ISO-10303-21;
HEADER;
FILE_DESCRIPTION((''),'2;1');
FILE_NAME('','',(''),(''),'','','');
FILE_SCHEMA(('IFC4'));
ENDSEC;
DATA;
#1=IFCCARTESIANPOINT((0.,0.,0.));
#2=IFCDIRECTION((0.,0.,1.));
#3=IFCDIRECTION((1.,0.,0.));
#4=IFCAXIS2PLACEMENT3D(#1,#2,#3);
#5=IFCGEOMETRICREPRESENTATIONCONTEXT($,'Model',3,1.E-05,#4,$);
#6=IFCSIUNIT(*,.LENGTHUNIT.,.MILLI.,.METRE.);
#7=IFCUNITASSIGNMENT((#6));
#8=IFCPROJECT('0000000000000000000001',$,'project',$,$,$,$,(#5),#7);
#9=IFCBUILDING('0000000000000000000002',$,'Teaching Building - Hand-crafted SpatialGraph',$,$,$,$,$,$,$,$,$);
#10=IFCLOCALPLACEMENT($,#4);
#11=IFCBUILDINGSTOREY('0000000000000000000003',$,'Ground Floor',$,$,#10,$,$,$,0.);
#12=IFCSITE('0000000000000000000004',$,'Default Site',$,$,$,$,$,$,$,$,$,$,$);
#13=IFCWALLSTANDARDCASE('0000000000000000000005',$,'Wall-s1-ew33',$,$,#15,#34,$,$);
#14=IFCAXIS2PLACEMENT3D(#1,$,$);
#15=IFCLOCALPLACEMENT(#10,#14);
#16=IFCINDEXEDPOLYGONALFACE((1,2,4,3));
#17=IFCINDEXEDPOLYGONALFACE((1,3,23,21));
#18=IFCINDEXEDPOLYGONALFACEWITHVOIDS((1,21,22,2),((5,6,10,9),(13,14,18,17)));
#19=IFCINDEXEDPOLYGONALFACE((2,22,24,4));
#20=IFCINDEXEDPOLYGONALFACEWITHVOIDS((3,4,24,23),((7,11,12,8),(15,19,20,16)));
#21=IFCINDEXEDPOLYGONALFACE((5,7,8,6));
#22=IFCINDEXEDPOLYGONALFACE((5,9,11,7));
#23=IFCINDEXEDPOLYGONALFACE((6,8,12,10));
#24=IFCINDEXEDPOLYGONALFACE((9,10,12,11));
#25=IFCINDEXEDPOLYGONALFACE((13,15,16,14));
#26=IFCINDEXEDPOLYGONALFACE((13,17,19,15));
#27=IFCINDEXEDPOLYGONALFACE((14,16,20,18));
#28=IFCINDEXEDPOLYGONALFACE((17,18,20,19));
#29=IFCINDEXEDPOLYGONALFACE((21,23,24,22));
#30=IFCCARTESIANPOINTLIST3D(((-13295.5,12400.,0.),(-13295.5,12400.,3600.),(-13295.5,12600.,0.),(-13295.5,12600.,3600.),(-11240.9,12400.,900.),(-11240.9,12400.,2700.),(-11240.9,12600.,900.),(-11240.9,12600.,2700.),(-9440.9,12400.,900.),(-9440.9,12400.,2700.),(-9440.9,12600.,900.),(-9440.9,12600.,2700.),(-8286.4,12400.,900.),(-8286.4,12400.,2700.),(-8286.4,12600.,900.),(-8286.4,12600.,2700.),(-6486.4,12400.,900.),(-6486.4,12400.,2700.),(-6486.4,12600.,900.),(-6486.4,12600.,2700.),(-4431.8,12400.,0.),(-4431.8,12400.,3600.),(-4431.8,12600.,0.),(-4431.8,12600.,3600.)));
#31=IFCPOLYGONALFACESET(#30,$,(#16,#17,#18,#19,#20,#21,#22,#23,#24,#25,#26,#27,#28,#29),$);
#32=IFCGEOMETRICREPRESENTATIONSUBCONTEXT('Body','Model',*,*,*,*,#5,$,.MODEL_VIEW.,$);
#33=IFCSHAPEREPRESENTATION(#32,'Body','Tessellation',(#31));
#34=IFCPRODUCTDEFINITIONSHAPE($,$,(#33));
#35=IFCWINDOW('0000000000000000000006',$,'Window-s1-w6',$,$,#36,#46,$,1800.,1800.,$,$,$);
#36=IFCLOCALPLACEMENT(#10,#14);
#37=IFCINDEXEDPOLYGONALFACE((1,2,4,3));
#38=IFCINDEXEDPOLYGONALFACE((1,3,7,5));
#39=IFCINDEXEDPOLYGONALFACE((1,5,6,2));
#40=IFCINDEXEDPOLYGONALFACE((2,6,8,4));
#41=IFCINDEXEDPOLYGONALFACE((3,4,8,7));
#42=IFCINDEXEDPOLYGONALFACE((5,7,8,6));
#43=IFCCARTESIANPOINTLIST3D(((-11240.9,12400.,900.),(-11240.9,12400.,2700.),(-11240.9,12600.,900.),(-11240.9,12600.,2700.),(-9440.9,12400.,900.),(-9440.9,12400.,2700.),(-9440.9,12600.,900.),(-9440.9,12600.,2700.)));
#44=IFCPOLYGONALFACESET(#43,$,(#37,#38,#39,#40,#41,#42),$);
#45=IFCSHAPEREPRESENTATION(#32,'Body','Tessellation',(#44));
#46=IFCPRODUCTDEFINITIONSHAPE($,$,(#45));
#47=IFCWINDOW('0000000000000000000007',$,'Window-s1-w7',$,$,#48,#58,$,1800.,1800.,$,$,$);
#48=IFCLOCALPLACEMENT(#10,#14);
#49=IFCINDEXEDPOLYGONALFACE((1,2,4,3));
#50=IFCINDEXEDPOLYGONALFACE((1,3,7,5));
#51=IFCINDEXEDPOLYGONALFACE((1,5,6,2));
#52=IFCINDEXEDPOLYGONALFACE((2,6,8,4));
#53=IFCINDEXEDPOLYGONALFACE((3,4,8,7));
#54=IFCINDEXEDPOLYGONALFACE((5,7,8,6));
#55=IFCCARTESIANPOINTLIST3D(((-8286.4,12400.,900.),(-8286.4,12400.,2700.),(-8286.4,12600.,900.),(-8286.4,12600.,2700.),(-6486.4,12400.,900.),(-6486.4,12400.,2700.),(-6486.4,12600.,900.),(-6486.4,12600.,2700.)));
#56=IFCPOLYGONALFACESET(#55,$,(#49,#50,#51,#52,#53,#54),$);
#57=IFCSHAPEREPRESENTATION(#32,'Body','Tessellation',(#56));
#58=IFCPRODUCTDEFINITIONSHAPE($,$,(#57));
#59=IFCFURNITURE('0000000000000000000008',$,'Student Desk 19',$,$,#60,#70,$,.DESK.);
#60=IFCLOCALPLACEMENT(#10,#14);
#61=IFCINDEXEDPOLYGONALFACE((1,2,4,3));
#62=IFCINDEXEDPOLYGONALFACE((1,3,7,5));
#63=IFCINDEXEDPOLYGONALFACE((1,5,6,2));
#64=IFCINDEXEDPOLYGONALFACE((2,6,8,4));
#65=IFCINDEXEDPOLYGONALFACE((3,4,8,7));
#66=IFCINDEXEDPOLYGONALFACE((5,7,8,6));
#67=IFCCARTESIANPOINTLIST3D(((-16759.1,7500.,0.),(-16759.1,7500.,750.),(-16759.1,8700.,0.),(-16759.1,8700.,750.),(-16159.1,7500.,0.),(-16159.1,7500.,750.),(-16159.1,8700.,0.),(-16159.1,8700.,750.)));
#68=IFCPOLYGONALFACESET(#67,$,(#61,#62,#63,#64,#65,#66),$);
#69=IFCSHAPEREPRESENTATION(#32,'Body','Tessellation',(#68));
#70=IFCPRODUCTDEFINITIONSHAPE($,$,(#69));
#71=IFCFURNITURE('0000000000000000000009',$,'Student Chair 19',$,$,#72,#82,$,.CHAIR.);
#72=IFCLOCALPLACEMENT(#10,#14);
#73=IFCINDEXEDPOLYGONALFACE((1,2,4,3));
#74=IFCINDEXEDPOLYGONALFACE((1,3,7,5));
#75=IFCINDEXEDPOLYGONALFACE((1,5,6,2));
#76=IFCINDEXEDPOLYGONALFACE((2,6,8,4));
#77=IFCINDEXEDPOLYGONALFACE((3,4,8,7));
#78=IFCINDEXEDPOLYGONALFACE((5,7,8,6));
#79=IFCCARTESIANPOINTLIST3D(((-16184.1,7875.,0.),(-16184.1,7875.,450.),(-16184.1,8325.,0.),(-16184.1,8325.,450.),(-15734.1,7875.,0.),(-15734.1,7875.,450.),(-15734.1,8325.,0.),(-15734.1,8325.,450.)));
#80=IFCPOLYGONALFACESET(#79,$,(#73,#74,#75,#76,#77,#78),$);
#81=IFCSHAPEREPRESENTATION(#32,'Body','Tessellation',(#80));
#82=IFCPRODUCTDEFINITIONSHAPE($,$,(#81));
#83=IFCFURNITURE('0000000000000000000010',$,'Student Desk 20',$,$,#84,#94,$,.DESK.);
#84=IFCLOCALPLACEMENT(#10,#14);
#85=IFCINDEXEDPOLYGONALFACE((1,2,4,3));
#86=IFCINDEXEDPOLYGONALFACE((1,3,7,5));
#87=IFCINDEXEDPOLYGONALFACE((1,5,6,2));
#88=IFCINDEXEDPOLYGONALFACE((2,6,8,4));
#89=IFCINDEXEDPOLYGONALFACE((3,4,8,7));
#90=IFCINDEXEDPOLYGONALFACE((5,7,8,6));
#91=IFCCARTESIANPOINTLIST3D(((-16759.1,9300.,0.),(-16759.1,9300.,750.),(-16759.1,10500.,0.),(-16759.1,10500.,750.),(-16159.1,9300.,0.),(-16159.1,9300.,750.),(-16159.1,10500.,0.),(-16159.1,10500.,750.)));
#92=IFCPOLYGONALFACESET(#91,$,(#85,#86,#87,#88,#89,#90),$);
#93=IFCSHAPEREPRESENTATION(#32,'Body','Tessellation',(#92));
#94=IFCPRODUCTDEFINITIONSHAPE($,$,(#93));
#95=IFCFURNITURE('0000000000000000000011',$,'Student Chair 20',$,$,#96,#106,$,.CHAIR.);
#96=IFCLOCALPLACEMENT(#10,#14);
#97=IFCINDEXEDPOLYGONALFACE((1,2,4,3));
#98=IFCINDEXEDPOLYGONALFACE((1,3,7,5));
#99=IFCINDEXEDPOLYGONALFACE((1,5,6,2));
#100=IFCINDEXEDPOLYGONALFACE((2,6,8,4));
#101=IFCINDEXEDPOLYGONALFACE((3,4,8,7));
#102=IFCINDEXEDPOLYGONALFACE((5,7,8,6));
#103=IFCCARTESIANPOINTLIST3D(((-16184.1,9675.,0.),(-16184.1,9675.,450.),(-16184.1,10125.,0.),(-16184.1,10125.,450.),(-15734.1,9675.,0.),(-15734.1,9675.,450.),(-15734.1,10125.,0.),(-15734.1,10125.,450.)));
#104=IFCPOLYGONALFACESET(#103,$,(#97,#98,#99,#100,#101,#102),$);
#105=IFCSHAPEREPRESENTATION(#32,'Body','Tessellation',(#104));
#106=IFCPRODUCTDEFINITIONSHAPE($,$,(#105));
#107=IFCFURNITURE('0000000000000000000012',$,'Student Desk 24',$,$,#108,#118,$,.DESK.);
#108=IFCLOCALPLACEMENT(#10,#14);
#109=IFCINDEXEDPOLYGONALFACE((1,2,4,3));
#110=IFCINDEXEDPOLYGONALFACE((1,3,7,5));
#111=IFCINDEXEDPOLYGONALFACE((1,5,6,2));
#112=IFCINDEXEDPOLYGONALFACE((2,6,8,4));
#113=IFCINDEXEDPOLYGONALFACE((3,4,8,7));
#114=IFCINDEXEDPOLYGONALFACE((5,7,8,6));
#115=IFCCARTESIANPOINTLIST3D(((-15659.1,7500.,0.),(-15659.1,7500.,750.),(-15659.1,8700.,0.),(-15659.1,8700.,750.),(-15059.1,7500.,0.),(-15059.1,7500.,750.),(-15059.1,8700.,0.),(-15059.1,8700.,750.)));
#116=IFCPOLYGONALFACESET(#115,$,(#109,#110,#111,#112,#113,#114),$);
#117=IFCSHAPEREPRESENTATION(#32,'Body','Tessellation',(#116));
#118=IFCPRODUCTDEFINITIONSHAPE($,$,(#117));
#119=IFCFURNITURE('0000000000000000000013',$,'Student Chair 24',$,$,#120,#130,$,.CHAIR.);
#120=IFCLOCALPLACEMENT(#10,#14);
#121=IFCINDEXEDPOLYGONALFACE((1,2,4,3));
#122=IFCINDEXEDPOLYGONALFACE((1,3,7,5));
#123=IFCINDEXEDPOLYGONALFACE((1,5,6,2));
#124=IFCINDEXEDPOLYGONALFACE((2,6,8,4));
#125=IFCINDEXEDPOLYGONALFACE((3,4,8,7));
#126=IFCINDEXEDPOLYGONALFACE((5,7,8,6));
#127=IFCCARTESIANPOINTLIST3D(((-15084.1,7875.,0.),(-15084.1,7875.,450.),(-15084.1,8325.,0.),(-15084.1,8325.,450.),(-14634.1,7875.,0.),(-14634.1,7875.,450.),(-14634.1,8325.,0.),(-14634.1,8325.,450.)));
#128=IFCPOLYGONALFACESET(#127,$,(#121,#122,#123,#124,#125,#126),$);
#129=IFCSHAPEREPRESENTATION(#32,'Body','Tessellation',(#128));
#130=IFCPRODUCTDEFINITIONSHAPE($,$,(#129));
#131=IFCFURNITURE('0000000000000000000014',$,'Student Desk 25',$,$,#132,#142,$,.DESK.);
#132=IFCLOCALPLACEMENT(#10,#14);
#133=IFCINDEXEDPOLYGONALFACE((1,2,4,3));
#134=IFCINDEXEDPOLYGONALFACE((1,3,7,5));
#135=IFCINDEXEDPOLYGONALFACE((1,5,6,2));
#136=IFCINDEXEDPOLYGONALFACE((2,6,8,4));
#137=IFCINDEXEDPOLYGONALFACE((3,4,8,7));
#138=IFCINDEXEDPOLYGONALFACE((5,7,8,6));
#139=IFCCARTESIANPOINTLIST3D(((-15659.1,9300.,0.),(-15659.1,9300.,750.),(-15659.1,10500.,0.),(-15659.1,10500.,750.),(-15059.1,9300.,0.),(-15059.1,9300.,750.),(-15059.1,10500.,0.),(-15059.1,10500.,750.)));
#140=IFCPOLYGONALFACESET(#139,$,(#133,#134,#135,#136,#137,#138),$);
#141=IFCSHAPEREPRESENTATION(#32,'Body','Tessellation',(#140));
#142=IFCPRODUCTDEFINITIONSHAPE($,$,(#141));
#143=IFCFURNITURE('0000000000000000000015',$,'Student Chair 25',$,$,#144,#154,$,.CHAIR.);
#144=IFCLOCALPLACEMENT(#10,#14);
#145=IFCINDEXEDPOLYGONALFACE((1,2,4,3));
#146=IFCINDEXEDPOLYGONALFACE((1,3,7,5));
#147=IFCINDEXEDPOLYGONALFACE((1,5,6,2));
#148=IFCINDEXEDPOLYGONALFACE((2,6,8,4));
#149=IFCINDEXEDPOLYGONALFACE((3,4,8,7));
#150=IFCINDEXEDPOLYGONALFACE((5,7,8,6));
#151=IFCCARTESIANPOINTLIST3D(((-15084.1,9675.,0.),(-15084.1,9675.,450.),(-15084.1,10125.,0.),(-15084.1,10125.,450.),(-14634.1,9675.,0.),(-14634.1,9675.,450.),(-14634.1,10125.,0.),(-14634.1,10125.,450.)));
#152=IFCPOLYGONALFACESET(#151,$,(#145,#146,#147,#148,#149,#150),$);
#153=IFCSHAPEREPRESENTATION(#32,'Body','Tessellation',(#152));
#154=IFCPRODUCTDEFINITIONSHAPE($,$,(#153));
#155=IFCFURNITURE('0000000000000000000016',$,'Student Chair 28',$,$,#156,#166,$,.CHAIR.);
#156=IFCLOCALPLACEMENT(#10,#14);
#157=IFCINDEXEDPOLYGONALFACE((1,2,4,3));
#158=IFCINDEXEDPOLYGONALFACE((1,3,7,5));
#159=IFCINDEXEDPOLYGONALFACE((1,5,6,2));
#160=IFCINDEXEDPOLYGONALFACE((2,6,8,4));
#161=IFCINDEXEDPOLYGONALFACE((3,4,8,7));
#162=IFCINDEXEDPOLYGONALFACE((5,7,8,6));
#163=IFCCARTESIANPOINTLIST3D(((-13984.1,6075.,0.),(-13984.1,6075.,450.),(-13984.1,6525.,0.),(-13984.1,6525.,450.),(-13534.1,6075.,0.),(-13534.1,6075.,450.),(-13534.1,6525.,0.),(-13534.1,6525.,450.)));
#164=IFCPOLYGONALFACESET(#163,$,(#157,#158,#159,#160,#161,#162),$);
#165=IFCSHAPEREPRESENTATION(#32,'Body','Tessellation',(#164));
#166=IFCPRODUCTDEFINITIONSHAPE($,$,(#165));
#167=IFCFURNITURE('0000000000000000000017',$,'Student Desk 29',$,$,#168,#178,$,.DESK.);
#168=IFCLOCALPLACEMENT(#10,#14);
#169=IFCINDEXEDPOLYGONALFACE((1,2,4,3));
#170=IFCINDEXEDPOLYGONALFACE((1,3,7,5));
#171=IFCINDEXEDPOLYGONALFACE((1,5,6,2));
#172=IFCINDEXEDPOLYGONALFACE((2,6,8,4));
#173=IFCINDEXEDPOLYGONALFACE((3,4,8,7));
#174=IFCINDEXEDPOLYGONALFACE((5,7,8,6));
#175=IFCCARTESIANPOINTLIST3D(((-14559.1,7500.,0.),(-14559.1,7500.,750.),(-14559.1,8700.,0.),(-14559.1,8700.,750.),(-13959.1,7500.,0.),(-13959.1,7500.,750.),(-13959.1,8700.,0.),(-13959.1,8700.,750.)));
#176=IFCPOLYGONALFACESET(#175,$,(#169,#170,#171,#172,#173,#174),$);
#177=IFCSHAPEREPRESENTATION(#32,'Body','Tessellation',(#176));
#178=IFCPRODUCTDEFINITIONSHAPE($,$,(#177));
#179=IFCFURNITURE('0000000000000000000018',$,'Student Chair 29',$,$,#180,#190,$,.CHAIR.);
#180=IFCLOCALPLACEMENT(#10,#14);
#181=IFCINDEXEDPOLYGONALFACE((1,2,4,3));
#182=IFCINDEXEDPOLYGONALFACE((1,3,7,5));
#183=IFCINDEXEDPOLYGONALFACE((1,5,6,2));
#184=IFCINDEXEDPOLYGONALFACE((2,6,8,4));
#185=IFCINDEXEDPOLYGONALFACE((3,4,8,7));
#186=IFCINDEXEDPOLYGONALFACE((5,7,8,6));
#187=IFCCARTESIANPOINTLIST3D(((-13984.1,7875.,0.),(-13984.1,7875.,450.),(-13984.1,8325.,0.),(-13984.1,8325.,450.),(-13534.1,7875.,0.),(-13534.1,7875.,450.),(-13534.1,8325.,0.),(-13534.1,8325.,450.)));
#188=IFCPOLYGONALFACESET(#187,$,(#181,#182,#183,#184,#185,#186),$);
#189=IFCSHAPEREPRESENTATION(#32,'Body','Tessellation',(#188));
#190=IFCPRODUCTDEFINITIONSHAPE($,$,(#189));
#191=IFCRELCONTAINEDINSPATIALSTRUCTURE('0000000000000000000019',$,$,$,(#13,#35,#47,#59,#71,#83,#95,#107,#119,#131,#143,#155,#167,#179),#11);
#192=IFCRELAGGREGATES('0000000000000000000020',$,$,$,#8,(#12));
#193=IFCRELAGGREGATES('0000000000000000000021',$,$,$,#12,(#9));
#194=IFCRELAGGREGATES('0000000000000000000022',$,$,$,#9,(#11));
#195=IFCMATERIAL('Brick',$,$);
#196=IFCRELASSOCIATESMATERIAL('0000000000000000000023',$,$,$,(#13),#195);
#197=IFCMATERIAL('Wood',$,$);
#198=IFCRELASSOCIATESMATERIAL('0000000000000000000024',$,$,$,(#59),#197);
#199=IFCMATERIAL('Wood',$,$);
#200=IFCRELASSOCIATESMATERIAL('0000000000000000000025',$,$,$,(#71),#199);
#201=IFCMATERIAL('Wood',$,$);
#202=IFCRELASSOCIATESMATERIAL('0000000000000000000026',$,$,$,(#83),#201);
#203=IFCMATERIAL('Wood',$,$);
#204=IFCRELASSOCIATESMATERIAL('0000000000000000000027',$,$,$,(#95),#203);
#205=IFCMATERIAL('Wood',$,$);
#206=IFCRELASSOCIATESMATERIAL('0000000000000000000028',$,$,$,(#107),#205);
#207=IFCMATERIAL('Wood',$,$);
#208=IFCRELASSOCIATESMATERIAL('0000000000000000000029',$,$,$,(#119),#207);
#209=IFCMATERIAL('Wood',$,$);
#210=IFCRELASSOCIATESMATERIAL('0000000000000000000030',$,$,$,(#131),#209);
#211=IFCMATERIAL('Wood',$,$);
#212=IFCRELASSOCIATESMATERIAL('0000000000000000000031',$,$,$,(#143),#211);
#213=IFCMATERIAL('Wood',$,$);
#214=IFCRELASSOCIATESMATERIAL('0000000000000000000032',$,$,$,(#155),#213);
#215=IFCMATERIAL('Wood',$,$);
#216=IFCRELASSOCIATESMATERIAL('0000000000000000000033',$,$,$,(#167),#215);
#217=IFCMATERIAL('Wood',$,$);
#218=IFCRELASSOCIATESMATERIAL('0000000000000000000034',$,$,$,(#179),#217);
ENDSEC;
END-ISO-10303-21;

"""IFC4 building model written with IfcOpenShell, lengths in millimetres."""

from ifc_helpers import new_model, si_unit, frame, frame_2d, origin_with_axes, origin_2d, place, context, subcontext, project, spatial, rectangle, extrude, material, element, fill, save


model = new_model("IFC4")

# Units and contexts
model_context = context("Model", 3, precision=1e-05, world=origin_with_axes())
body_context = subcontext(model_context, "Body", "Model", "MODEL_VIEW")
ifc_project = project(units=[si_unit("LENGTHUNIT", "METRE", prefix="MILLI")], contexts=[model_context])

# Site, building, storey
site = spatial("IfcSite", under=ifc_project, Name="Default Site")
building = spatial("IfcBuilding", under=site, Name="Teaching Building - Hand-crafted SpatialGraph")
storey_placement = place(None, origin_with_axes())
storey = spatial("IfcBuildingStorey", under=building, at=storey_placement, Name="Ground Floor", Elevation=0.0)

# Wall, openings, windows
ifc_material_1 = material(Name="Brick")
wall_placement = place(storey_placement, frame((-13295.5, 12500.0, 0.0), z_axis=(0.0, 0.0, 1.0), x_axis=(1.0, 0.0, 0.0)))
wall = element("IfcWallStandardCase", 1, at=wall_placement, inside=storey, material=ifc_material_1, Name="Wall-s1-ew33", context=body_context, shape_type="SweptSolid", body=[
    extrude(rectangle(XDim=8863.6, YDim=200.0, at=frame_2d((4431.8, 0.0))), origin_with_axes(), (0.0, 0.0, 1.0), 3600.0),
])
opening_1_placement = place(wall_placement, frame((2054.5, 0.0, 900.0), z_axis=(0.0, 0.0, 1.0), x_axis=(1.0, 0.0, 0.0)))
opening_1 = element("IfcOpeningElement", 2, at=opening_1_placement, cuts=wall, context=body_context, shape_type="SweptSolid", body=[
    extrude(rectangle(XDim=1800.0, YDim=400.0, at=frame_2d((900.0, 0.0))), origin_with_axes(), (0.0, 0.0, 1.0), 1800.0),
])
opening_2_placement = place(wall_placement, frame((5009.1, 0.0, 900.0), z_axis=(0.0, 0.0, 1.0), x_axis=(1.0, 0.0, 0.0)))
opening_2 = element("IfcOpeningElement", 3, at=opening_2_placement, cuts=wall, context=body_context, shape_type="SweptSolid", body=[
    extrude(rectangle(XDim=1800.0, YDim=400.0, at=frame_2d((900.0, 0.0))), origin_with_axes(), (0.0, 0.0, 1.0), 1800.0),
])
window_1_placement = place(storey_placement, frame((-11240.9, 12500.0, 900.0), z_axis=(0.0, 0.0, 1.0), x_axis=(1.0, 0.0, 0.0)))
window_1 = element("IfcWindow", 4, at=window_1_placement, inside=storey, Name="Window-s1-w6", OverallHeight=1800.0, OverallWidth=1800.0, context=body_context, shape_type="SweptSolid", body=[
    extrude(rectangle(XDim=1800.0, YDim=200.0, at=frame_2d((900.0, 0.0))), origin_with_axes(), (0.0, 0.0, 1.0), 1800.0),
])
fill(opening_1, window_1)
window_2_placement = place(storey_placement, frame((-8286.4, 12500.0, 900.0), z_axis=(0.0, 0.0, 1.0), x_axis=(1.0, 0.0, 0.0)))
window_2 = element("IfcWindow", 5, at=window_2_placement, inside=storey, Name="Window-s1-w7", OverallHeight=1800.0, OverallWidth=1800.0, context=body_context, shape_type="SweptSolid", body=[
    extrude(rectangle(XDim=1800.0, YDim=200.0, at=frame_2d((900.0, 0.0))), origin_with_axes(), (0.0, 0.0, 1.0), 1800.0),
])
fill(opening_2, window_2)

# Furniture
ifc_material_2 = material(Name="Wood")
furniture_1_placement = place(storey_placement, frame((-16459.1, 8100.0, 0.0), z_axis=(0.0, 0.0, 1.0), x_axis=(0.0, 1.0, 0.0)))
element("IfcFurniture", 6, at=furniture_1_placement, inside=storey, material=ifc_material_2, Name="Student Desk 19", PredefinedType="DESK", context=body_context, shape_type="SweptSolid", body=[
    extrude(rectangle(XDim=1200.0, YDim=600.0, at=origin_2d()), origin_with_axes(), (0.0, 0.0, 1.0), 750.0),
])
ifc_material_3 = material(Name="Wood")
furniture_2_placement = place(storey_placement, frame((-15959.1, 8100.0, 0.0), z_axis=(0.0, 0.0, 1.0), x_axis=(1.0, 0.0, 0.0)))
element("IfcFurniture", 7, at=furniture_2_placement, inside=storey, material=ifc_material_3, Name="Student Chair 19", PredefinedType="CHAIR", context=body_context, shape_type="SweptSolid", body=[
    extrude(rectangle(XDim=450.0, YDim=450.0, at=origin_2d()), origin_with_axes(), (0.0, 0.0, 1.0), 450.0),
])
ifc_material_4 = material(Name="Wood")
furniture_3_placement = place(storey_placement, frame((-16459.1, 9900.0, 0.0), z_axis=(0.0, 0.0, 1.0), x_axis=(0.0, 1.0, 0.0)))
element("IfcFurniture", 8, at=furniture_3_placement, inside=storey, material=ifc_material_4, Name="Student Desk 20", PredefinedType="DESK", context=body_context, shape_type="SweptSolid", body=[
    extrude(rectangle(XDim=1200.0, YDim=600.0, at=origin_2d()), origin_with_axes(), (0.0, 0.0, 1.0), 750.0),
])
ifc_material_5 = material(Name="Wood")
furniture_4_placement = place(storey_placement, frame((-15959.1, 9900.0, 0.0), z_axis=(0.0, 0.0, 1.0), x_axis=(1.0, 0.0, 0.0)))
element("IfcFurniture", 9, at=furniture_4_placement, inside=storey, material=ifc_material_5, Name="Student Chair 20", PredefinedType="CHAIR", context=body_context, shape_type="SweptSolid", body=[
    extrude(rectangle(XDim=450.0, YDim=450.0, at=origin_2d()), origin_with_axes(), (0.0, 0.0, 1.0), 450.0),
])
ifc_material_6 = material(Name="Wood")
furniture_5_placement = place(storey_placement, frame((-15359.1, 8100.0, 0.0), z_axis=(0.0, 0.0, 1.0), x_axis=(0.0, 1.0, 0.0)))
element("IfcFurniture", 10, at=furniture_5_placement, inside=storey, material=ifc_material_6, Name="Student Desk 24", PredefinedType="DESK", context=body_context, shape_type="SweptSolid", body=[
    extrude(rectangle(XDim=1200.0, YDim=600.0, at=origin_2d()), origin_with_axes(), (0.0, 0.0, 1.0), 750.0),
])
ifc_material_7 = material(Name="Wood")
furniture_6_placement = place(storey_placement, frame((-14859.1, 8100.0, 0.0), z_axis=(0.0, 0.0, 1.0), x_axis=(1.0, 0.0, 0.0)))
element("IfcFurniture", 11, at=furniture_6_placement, inside=storey, material=ifc_material_7, Name="Student Chair 24", PredefinedType="CHAIR", context=body_context, shape_type="SweptSolid", body=[
    extrude(rectangle(XDim=450.0, YDim=450.0, at=origin_2d()), origin_with_axes(), (0.0, 0.0, 1.0), 450.0),
])
ifc_material_8 = material(Name="Wood")
furniture_7_placement = place(storey_placement, frame((-15359.1, 9900.0, 0.0), z_axis=(0.0, 0.0, 1.0), x_axis=(0.0, 1.0, 0.0)))
element("IfcFurniture", 12, at=furniture_7_placement, inside=storey, material=ifc_material_8, Name="Student Desk 25", PredefinedType="DESK", context=body_context, shape_type="SweptSolid", body=[
    extrude(rectangle(XDim=1200.0, YDim=600.0, at=origin_2d()), origin_with_axes(), (0.0, 0.0, 1.0), 750.0),
])
ifc_material_9 = material(Name="Wood")
furniture_8_placement = place(storey_placement, frame((-14859.1, 9900.0, 0.0), z_axis=(0.0, 0.0, 1.0), x_axis=(1.0, 0.0, 0.0)))
element("IfcFurniture", 13, at=furniture_8_placement, inside=storey, material=ifc_material_9, Name="Student Chair 25", PredefinedType="CHAIR", context=body_context, shape_type="SweptSolid", body=[
    extrude(rectangle(XDim=450.0, YDim=450.0, at=origin_2d()), origin_with_axes(), (0.0, 0.0, 1.0), 450.0),
])
ifc_material_10 = material(Name="Wood")
furniture_9_placement = place(storey_placement, frame((-13759.1, 6300.0, 0.0), z_axis=(0.0, 0.0, 1.0), x_axis=(1.0, 0.0, 0.0)))
element("IfcFurniture", 14, at=furniture_9_placement, inside=storey, material=ifc_material_10, Name="Student Chair 28", PredefinedType="CHAIR", context=body_context, shape_type="SweptSolid", body=[
    extrude(rectangle(XDim=450.0, YDim=450.0, at=origin_2d()), origin_with_axes(), (0.0, 0.0, 1.0), 450.0),
])
ifc_material_11 = material(Name="Wood")
furniture_10_placement = place(storey_placement, frame((-14259.1, 8100.0, 0.0), z_axis=(0.0, 0.0, 1.0), x_axis=(0.0, 1.0, 0.0)))
element("IfcFurniture", 15, at=furniture_10_placement, inside=storey, material=ifc_material_11, Name="Student Desk 29", PredefinedType="DESK", context=body_context, shape_type="SweptSolid", body=[
    extrude(rectangle(XDim=1200.0, YDim=600.0, at=origin_2d()), origin_with_axes(), (0.0, 0.0, 1.0), 750.0),
])
ifc_material_12 = material(Name="Wood")
furniture_11_placement = place(storey_placement, frame((-13759.1, 8100.0, 0.0), z_axis=(0.0, 0.0, 1.0), x_axis=(1.0, 0.0, 0.0)))
element("IfcFurniture", 16, at=furniture_11_placement, inside=storey, material=ifc_material_12, Name="Student Chair 29", PredefinedType="CHAIR", context=body_context, shape_type="SweptSolid", body=[
    extrude(rectangle(XDim=450.0, YDim=450.0, at=origin_2d()), origin_with_axes(), (0.0, 0.0, 1.0), 450.0),
])

save(model, "model.ifc")
